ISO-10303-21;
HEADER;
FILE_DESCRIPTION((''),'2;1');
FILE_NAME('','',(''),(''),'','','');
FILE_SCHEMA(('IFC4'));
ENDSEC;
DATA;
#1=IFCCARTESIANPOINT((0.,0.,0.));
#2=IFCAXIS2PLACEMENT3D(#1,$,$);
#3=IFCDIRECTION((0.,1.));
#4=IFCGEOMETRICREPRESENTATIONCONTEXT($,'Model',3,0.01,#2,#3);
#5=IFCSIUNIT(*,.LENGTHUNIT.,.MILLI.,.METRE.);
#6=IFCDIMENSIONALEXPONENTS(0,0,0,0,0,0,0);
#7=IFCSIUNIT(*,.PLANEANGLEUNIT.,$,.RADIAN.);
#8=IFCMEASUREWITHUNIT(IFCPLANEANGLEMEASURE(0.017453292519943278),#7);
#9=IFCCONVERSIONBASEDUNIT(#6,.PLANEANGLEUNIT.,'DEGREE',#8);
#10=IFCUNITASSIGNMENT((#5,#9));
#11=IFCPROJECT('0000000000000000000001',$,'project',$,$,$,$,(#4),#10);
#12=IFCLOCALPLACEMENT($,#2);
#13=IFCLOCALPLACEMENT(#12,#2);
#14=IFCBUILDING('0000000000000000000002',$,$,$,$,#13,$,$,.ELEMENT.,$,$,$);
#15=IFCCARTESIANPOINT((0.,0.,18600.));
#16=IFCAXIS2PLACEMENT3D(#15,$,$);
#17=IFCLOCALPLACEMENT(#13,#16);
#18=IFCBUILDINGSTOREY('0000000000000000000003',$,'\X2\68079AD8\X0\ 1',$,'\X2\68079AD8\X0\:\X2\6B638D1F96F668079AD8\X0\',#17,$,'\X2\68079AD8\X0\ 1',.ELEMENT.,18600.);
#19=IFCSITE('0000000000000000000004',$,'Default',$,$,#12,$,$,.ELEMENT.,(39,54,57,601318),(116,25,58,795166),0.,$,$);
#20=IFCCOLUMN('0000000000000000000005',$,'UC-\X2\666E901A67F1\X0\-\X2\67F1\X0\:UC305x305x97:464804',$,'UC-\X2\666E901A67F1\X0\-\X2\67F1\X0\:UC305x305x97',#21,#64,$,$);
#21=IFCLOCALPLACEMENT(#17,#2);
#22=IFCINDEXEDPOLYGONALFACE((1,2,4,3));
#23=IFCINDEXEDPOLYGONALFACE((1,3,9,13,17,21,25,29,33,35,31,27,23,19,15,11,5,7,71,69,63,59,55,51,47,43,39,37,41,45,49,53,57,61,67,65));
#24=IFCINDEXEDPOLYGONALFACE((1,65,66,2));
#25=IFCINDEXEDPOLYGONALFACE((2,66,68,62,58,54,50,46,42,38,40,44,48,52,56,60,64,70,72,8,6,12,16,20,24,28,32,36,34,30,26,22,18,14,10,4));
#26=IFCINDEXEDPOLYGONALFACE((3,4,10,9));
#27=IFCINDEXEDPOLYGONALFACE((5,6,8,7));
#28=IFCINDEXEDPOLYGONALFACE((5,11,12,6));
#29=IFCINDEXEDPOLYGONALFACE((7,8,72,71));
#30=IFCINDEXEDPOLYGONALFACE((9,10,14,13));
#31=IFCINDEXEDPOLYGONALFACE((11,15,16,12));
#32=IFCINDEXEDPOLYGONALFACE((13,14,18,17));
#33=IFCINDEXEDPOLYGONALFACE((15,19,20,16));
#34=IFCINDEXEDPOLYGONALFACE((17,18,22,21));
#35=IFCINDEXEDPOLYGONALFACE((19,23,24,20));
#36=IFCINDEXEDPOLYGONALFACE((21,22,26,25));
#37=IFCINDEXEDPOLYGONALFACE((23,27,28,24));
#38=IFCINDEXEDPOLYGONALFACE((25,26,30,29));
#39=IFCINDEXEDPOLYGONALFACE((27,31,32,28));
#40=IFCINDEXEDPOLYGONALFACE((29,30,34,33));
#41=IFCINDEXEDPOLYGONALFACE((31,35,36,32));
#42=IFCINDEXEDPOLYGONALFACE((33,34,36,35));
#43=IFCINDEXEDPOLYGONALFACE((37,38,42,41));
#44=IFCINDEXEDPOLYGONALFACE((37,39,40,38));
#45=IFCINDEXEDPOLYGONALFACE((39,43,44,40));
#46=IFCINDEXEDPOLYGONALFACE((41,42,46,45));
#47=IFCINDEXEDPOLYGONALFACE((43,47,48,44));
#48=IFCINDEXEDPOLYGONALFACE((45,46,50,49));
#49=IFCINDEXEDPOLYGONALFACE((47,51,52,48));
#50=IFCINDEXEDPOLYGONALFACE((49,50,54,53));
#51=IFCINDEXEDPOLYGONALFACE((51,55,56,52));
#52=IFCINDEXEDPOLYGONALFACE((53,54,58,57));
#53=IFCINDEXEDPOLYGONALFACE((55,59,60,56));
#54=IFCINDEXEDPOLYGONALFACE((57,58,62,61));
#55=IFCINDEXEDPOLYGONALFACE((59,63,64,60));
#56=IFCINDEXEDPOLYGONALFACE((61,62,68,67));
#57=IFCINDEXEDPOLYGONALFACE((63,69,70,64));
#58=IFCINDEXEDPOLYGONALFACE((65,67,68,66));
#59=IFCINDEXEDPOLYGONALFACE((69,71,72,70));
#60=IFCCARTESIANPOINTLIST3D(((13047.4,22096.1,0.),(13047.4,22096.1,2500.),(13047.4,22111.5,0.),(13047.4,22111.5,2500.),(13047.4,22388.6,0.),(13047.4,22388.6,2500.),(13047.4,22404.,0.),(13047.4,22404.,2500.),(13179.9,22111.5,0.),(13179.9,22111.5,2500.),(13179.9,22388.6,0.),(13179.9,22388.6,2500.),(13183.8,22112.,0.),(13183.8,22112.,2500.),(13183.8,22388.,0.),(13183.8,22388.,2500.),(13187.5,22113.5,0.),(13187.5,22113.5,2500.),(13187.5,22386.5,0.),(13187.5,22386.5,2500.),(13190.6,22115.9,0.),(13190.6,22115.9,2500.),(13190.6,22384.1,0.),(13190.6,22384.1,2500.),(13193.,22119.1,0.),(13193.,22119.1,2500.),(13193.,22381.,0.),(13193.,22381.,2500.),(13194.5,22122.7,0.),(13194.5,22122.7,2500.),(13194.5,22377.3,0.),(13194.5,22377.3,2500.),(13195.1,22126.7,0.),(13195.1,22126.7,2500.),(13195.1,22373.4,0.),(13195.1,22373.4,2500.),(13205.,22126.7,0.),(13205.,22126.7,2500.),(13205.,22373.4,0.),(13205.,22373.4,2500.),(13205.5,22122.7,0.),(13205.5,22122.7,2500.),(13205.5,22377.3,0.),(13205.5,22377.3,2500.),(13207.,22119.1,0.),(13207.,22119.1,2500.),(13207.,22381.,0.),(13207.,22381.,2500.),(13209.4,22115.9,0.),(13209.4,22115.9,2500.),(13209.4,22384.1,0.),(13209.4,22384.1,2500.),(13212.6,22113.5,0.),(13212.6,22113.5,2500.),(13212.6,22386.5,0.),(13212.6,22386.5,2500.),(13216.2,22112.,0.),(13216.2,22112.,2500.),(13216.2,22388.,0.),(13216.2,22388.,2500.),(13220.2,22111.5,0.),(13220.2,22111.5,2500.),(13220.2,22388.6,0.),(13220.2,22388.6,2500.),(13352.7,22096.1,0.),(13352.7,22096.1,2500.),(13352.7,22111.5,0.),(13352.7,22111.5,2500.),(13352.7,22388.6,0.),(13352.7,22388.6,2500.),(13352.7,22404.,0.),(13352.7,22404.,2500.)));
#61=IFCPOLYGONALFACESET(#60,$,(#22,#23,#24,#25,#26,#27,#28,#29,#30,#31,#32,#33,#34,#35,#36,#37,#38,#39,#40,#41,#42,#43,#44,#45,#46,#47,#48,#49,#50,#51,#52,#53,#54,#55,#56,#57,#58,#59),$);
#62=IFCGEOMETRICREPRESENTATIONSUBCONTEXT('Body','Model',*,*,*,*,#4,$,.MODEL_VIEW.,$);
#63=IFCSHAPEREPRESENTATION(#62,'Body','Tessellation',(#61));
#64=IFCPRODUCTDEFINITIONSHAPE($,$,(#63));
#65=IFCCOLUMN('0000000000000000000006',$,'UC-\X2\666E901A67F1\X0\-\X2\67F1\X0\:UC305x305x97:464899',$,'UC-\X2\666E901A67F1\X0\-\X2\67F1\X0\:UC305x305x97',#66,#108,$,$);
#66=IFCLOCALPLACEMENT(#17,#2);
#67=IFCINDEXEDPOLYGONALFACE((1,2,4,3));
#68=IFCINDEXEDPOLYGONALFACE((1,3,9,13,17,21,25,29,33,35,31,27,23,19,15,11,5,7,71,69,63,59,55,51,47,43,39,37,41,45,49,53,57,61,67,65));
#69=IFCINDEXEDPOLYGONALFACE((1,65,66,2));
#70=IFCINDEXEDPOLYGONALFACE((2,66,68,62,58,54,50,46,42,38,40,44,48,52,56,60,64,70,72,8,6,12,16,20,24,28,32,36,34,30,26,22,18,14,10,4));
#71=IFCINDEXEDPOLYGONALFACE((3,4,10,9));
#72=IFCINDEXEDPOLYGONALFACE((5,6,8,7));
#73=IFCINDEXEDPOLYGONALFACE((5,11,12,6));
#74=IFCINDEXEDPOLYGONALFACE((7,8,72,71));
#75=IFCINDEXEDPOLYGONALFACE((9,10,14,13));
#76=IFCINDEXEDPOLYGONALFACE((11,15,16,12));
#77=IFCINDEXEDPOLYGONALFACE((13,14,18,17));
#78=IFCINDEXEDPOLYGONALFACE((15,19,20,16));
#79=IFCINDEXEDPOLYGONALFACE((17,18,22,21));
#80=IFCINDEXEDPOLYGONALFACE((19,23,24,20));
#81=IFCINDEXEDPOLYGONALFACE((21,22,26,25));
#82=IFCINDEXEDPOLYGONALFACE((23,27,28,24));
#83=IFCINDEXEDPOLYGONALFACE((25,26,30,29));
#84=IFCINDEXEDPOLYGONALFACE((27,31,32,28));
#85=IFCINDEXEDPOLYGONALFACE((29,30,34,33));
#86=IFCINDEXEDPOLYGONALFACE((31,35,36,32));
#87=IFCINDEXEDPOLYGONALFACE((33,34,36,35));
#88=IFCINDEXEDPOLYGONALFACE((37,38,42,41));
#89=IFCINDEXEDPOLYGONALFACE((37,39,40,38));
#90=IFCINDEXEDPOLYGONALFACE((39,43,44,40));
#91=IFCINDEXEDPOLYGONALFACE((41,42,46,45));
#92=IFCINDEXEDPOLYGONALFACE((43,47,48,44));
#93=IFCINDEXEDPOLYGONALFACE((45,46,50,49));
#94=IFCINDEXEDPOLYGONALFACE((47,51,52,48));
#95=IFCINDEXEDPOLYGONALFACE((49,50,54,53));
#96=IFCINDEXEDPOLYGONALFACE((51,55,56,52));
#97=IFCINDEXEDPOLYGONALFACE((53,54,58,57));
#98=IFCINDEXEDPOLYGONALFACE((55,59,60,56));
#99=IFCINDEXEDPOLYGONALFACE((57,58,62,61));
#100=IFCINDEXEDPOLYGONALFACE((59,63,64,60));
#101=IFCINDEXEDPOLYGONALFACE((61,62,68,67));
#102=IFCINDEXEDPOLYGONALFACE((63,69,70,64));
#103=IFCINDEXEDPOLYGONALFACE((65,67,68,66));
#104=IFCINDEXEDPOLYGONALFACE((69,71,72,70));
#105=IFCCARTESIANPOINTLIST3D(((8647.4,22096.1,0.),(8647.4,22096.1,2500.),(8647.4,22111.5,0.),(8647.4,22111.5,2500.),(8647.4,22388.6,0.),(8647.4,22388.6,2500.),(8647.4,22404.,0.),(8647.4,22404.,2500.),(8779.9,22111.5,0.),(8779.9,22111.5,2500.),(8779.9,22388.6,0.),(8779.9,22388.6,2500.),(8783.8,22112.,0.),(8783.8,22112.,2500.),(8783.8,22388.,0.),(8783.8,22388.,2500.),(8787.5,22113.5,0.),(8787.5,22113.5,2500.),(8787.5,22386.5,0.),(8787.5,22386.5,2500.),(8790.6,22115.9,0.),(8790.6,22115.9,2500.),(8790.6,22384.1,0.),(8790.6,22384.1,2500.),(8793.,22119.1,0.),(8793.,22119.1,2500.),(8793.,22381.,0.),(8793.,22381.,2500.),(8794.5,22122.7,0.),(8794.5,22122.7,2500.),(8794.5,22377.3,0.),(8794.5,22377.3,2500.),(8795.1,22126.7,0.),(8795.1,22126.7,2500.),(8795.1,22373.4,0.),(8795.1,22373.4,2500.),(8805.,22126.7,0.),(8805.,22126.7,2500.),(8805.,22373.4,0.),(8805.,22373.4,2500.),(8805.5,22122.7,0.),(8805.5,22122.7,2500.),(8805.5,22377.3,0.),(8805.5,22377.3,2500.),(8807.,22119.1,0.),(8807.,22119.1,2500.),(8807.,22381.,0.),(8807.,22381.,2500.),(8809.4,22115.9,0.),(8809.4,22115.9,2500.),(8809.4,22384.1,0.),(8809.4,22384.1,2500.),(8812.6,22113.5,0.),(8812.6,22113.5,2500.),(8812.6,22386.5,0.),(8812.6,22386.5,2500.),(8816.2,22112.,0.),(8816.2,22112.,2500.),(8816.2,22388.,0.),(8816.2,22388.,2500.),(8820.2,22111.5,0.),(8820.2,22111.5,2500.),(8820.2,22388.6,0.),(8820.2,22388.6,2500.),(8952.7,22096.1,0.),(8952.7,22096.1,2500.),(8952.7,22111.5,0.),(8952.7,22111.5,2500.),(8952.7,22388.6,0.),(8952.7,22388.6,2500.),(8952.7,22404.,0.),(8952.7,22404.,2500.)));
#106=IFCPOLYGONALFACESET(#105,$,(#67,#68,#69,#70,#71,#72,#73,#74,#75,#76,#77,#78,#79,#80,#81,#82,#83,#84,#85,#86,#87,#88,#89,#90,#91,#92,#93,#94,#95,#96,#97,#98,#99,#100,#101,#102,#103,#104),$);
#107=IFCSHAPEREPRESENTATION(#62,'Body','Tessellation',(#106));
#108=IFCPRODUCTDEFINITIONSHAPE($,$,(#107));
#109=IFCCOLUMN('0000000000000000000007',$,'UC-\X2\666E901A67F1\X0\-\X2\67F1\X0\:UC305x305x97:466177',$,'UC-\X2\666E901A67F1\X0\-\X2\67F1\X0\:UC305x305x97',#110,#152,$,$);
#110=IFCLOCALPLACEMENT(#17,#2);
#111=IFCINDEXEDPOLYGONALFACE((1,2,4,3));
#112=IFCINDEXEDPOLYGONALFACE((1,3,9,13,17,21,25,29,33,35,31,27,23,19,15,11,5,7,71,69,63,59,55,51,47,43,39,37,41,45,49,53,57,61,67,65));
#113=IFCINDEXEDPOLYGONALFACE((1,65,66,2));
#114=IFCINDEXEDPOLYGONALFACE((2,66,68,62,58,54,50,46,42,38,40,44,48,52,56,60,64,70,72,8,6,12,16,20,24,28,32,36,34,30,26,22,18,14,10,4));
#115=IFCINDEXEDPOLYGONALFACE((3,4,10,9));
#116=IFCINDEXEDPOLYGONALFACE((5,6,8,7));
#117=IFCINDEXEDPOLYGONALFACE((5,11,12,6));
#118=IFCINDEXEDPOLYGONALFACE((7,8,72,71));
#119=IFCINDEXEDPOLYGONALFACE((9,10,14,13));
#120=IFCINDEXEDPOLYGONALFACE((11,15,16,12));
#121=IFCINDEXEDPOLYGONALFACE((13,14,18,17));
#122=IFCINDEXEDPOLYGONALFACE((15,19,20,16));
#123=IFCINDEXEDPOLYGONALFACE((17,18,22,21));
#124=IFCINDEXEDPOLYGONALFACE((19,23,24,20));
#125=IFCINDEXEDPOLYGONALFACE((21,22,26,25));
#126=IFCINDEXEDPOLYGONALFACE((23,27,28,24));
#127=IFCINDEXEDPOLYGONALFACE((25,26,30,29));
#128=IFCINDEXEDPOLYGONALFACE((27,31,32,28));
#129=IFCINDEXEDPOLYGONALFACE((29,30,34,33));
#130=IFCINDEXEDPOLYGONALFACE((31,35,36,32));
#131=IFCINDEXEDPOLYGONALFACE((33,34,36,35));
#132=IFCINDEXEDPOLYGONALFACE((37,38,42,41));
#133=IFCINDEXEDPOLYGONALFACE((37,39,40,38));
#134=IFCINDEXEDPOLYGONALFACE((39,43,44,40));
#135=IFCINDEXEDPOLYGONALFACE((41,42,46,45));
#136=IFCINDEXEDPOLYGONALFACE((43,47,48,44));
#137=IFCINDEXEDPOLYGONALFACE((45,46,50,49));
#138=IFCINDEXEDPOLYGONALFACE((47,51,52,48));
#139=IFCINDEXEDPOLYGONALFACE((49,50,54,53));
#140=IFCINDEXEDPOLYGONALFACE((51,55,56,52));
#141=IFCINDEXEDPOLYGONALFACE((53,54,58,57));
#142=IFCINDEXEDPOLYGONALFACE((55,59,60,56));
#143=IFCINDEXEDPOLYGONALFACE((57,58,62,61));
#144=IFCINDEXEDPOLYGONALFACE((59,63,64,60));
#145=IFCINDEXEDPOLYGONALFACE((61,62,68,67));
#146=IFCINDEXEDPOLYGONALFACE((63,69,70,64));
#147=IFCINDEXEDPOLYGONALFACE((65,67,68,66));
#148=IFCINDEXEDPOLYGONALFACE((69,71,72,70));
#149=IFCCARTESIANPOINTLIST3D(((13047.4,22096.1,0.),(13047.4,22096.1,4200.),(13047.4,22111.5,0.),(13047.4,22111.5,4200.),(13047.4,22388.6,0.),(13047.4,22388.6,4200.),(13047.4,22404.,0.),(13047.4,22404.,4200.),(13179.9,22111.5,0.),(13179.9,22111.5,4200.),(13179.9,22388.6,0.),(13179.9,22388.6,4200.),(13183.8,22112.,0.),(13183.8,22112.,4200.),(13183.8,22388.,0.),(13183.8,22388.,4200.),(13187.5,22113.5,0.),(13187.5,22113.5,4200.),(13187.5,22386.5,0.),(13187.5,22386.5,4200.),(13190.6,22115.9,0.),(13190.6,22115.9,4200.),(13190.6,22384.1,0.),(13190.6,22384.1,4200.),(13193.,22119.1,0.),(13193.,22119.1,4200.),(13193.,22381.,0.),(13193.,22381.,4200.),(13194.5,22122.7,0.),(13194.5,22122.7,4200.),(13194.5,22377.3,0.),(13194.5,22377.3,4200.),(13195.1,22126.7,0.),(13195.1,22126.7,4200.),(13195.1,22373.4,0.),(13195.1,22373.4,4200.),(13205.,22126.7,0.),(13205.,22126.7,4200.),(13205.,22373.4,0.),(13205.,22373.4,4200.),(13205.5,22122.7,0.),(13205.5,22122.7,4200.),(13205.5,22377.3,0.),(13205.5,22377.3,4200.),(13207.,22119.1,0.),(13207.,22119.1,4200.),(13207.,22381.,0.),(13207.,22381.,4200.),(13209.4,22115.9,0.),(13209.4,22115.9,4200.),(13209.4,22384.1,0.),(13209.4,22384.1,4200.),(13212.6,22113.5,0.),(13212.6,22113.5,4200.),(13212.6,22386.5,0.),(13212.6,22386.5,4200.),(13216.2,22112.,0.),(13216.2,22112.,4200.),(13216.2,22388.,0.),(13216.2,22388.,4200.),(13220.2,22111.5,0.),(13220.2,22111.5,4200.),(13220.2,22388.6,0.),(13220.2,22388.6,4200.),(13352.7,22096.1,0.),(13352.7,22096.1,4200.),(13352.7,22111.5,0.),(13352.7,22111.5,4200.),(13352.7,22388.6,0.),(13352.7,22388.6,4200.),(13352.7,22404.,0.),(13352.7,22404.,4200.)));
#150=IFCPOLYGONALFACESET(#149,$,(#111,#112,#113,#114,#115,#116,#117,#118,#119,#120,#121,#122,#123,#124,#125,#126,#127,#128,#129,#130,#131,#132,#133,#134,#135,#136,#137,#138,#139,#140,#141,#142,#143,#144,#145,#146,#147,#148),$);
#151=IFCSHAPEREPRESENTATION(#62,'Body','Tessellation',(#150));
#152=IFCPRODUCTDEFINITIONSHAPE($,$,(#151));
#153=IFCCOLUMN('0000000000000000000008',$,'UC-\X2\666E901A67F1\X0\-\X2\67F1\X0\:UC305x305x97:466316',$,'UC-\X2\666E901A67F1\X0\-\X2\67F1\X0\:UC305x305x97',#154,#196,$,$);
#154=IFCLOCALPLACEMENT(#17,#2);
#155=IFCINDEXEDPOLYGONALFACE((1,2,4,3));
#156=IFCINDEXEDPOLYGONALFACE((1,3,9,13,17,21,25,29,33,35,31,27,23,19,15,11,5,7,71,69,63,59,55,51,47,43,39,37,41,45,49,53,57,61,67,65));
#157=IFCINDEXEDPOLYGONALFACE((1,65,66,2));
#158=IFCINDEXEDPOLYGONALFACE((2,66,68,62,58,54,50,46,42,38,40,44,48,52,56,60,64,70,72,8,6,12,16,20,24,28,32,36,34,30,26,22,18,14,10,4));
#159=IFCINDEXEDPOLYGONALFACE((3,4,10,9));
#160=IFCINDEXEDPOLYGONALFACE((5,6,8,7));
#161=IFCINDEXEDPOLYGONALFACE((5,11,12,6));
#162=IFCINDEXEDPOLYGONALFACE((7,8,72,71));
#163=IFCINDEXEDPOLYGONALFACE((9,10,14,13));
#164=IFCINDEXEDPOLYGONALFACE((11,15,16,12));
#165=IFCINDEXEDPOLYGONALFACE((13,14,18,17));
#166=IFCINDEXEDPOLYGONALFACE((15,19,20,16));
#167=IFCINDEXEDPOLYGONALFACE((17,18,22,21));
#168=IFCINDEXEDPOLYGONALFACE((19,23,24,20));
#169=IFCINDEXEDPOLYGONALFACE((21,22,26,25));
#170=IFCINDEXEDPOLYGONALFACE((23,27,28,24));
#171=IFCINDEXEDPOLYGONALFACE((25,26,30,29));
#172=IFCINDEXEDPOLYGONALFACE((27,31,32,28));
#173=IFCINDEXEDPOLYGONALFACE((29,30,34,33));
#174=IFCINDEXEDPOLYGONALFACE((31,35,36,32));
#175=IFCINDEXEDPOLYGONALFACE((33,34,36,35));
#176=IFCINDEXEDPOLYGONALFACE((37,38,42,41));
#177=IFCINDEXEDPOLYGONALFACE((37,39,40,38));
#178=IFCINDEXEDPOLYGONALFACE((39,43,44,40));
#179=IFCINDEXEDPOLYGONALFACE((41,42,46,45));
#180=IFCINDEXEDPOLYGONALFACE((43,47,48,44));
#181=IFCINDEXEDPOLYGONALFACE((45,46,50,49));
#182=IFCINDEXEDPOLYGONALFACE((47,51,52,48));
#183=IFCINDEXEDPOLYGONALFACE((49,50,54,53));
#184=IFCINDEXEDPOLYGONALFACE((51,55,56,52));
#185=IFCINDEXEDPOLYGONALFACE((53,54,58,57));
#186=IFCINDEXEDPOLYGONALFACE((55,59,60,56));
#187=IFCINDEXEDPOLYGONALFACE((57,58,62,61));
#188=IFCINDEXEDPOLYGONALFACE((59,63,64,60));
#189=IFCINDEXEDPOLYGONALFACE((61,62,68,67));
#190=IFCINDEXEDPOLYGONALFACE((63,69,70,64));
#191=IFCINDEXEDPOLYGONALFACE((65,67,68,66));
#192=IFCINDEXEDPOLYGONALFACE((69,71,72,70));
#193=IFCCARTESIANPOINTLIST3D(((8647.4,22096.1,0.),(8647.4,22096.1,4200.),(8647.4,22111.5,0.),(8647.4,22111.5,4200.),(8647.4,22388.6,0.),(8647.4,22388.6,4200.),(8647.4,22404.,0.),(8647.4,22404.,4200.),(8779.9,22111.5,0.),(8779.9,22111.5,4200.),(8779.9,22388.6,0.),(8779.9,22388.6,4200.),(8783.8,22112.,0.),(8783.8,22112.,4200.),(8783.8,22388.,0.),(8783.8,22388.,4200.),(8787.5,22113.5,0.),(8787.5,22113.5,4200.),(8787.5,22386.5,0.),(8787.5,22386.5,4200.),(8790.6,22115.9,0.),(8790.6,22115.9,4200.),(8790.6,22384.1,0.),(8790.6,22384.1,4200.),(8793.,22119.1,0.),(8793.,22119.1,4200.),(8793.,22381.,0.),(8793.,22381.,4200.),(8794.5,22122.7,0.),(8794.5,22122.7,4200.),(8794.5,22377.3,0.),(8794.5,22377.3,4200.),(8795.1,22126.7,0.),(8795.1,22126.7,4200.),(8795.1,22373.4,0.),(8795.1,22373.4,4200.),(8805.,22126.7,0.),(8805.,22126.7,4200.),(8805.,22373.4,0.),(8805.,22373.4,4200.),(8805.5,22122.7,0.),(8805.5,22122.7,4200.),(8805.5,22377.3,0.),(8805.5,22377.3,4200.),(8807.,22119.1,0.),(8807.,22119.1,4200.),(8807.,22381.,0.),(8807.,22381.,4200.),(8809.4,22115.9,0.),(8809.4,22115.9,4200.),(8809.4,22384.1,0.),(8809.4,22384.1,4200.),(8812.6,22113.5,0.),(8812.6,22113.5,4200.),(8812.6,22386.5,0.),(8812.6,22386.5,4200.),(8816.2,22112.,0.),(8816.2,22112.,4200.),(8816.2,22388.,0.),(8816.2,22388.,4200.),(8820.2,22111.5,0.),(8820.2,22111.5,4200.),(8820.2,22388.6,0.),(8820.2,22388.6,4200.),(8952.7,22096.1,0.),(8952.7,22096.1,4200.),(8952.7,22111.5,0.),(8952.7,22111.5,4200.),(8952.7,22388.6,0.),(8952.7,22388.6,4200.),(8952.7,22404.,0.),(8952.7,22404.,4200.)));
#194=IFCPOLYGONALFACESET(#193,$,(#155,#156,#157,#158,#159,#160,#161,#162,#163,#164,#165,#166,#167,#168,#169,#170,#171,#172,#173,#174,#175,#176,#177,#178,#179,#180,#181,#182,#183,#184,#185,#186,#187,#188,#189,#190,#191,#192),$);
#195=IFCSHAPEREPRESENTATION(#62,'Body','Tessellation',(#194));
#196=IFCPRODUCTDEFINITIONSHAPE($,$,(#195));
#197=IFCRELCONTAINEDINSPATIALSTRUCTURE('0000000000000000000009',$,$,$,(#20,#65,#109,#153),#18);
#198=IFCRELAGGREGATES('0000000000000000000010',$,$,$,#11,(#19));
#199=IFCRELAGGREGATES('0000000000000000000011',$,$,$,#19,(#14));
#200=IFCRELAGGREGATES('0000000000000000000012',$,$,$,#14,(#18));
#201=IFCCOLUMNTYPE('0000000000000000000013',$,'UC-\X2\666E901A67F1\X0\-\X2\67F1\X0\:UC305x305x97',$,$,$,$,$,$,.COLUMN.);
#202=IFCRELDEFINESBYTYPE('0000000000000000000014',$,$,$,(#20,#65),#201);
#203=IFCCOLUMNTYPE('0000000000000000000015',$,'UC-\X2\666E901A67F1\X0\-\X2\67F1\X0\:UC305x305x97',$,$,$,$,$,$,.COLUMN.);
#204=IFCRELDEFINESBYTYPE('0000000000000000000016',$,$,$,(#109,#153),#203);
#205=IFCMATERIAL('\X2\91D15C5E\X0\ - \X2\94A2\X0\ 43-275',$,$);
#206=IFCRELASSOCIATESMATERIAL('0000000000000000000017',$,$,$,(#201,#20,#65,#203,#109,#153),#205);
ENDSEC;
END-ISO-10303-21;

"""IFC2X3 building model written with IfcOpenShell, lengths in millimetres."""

from ifc_helpers import new_model, entity, si_unit, converted_unit, direction, frame, origin, origin_2d_with_axis, place, context, subcontext, project, spatial, i_section, extrude, source, transform, mapped, material, type_object, type_shapes, element, save


model = new_model("IFC2X3")

# Units and contexts
model_context = context("Model", 3, precision=0.01, world=origin(), true_north=direction((0.0, 1.0)))
body_context = subcontext(model_context, "Body", "Model", "MODEL_VIEW")
ifc_project = project(units=[si_unit("LENGTHUNIT", "METRE", prefix="MILLI"), converted_unit("PLANEANGLEUNIT", "DEGREE", entity("IfcPlaneAngleMeasure", 0.017453292519943278), si_unit("PLANEANGLEUNIT", "RADIAN"), dimensions=[0, 0, 0, 0, 0, 0, 0])], contexts=[model_context])

# Site, building, storey
site_placement = place(None, origin())
site = spatial("IfcSite", under=ifc_project, at=site_placement, Name="Default", CompositionType="ELEMENT", RefLatitude=(39, 54, 57, 601318), RefLongitude=(116, 25, 58, 795166), RefElevation=0.0)
building_placement = place(site_placement, origin())
building = spatial("IfcBuilding", under=site, at=building_placement, CompositionType="ELEMENT")
storey_placement = place(building_placement, frame((0.0, 0.0, 18600.0)))
storey = spatial("IfcBuildingStorey", under=building, at=storey_placement, Name="标高 1", ObjectType="标高:正负零标高", LongName="标高 1", CompositionType="ELEMENT", Elevation=18600.0)

# Columns
ifc_material_1 = material(Name="金属 - 钢 43-275")
column_type_1 = type_object("IfcColumnType", Name="UC-普通柱-柱:UC305x305x97", PredefinedType="COLUMN", material=ifc_material_1)
shared_shape_1 = source(origin(), body_context, "Body", "SweptSolid", [
    extrude(i_section(OverallWidth=305.3, OverallDepth=307.9, WebThickness=9.9, FlangeThickness=15.4, FilletRadius=15.2, at=origin_2d_with_axis()), frame((0.0, 0.0, 18600.0), z_axis=(0.0, 0.0, 1.0), x_axis=(-1.0, 0.0, 0.0)), (0.0, 0.0, 1.0), 2500.0),
])
type_shapes(column_type_1, [shared_shape_1])
for number, where, name in (
    (1, (13200.0, 22250.0, -18600.0), "UC-普通柱-柱:UC305x305x97:464804"),
    (2, (8800.0, 22250.0, -18600.0), "UC-普通柱-柱:UC305x305x97:464899"),
):
    element("IfcColumn", number, at=place(storey_placement, frame(where)), inside=storey, type_object=column_type_1, material=ifc_material_1, Name=name, ObjectType="UC-普通柱-柱:UC305x305x97", context=body_context, shape_type="MappedRepresentation", body=[
        mapped(shared_shape_1, transform((0.0, 0.0, 0.0), scale=1.0)),
    ])
column_type_2 = type_object("IfcColumnType", Name="UC-普通柱-柱:UC305x305x97", PredefinedType="COLUMN", material=ifc_material_1)
shared_shape_2 = source(origin(), body_context, "Body", "SweptSolid", [
    extrude(i_section(OverallWidth=305.3, OverallDepth=307.9, WebThickness=9.9, FlangeThickness=15.4, FilletRadius=15.2, at=origin_2d_with_axis()), frame((0.0, 0.0, 18600.0), z_axis=(0.0, 0.0, 1.0), x_axis=(-1.0, 0.0, 0.0)), (0.0, 0.0, 1.0), 4200.0),
])
type_shapes(column_type_2, [shared_shape_2])
for number, where, name in (
    (3, (13200.0, 22250.0, -18600.0), "UC-普通柱-柱:UC305x305x97:466177"),
    (4, (8800.0, 22250.0, -18600.0), "UC-普通柱-柱:UC305x305x97:466316"),
):
    element("IfcColumn", number, at=place(storey_placement, frame(where)), inside=storey, type_object=column_type_2, material=ifc_material_1, Name=name, ObjectType="UC-普通柱-柱:UC305x305x97", context=body_context, shape_type="MappedRepresentation", body=[
        mapped(shared_shape_2, transform((0.0, 0.0, 0.0), scale=1.0)),
    ])

save(model, "model.ifc")
